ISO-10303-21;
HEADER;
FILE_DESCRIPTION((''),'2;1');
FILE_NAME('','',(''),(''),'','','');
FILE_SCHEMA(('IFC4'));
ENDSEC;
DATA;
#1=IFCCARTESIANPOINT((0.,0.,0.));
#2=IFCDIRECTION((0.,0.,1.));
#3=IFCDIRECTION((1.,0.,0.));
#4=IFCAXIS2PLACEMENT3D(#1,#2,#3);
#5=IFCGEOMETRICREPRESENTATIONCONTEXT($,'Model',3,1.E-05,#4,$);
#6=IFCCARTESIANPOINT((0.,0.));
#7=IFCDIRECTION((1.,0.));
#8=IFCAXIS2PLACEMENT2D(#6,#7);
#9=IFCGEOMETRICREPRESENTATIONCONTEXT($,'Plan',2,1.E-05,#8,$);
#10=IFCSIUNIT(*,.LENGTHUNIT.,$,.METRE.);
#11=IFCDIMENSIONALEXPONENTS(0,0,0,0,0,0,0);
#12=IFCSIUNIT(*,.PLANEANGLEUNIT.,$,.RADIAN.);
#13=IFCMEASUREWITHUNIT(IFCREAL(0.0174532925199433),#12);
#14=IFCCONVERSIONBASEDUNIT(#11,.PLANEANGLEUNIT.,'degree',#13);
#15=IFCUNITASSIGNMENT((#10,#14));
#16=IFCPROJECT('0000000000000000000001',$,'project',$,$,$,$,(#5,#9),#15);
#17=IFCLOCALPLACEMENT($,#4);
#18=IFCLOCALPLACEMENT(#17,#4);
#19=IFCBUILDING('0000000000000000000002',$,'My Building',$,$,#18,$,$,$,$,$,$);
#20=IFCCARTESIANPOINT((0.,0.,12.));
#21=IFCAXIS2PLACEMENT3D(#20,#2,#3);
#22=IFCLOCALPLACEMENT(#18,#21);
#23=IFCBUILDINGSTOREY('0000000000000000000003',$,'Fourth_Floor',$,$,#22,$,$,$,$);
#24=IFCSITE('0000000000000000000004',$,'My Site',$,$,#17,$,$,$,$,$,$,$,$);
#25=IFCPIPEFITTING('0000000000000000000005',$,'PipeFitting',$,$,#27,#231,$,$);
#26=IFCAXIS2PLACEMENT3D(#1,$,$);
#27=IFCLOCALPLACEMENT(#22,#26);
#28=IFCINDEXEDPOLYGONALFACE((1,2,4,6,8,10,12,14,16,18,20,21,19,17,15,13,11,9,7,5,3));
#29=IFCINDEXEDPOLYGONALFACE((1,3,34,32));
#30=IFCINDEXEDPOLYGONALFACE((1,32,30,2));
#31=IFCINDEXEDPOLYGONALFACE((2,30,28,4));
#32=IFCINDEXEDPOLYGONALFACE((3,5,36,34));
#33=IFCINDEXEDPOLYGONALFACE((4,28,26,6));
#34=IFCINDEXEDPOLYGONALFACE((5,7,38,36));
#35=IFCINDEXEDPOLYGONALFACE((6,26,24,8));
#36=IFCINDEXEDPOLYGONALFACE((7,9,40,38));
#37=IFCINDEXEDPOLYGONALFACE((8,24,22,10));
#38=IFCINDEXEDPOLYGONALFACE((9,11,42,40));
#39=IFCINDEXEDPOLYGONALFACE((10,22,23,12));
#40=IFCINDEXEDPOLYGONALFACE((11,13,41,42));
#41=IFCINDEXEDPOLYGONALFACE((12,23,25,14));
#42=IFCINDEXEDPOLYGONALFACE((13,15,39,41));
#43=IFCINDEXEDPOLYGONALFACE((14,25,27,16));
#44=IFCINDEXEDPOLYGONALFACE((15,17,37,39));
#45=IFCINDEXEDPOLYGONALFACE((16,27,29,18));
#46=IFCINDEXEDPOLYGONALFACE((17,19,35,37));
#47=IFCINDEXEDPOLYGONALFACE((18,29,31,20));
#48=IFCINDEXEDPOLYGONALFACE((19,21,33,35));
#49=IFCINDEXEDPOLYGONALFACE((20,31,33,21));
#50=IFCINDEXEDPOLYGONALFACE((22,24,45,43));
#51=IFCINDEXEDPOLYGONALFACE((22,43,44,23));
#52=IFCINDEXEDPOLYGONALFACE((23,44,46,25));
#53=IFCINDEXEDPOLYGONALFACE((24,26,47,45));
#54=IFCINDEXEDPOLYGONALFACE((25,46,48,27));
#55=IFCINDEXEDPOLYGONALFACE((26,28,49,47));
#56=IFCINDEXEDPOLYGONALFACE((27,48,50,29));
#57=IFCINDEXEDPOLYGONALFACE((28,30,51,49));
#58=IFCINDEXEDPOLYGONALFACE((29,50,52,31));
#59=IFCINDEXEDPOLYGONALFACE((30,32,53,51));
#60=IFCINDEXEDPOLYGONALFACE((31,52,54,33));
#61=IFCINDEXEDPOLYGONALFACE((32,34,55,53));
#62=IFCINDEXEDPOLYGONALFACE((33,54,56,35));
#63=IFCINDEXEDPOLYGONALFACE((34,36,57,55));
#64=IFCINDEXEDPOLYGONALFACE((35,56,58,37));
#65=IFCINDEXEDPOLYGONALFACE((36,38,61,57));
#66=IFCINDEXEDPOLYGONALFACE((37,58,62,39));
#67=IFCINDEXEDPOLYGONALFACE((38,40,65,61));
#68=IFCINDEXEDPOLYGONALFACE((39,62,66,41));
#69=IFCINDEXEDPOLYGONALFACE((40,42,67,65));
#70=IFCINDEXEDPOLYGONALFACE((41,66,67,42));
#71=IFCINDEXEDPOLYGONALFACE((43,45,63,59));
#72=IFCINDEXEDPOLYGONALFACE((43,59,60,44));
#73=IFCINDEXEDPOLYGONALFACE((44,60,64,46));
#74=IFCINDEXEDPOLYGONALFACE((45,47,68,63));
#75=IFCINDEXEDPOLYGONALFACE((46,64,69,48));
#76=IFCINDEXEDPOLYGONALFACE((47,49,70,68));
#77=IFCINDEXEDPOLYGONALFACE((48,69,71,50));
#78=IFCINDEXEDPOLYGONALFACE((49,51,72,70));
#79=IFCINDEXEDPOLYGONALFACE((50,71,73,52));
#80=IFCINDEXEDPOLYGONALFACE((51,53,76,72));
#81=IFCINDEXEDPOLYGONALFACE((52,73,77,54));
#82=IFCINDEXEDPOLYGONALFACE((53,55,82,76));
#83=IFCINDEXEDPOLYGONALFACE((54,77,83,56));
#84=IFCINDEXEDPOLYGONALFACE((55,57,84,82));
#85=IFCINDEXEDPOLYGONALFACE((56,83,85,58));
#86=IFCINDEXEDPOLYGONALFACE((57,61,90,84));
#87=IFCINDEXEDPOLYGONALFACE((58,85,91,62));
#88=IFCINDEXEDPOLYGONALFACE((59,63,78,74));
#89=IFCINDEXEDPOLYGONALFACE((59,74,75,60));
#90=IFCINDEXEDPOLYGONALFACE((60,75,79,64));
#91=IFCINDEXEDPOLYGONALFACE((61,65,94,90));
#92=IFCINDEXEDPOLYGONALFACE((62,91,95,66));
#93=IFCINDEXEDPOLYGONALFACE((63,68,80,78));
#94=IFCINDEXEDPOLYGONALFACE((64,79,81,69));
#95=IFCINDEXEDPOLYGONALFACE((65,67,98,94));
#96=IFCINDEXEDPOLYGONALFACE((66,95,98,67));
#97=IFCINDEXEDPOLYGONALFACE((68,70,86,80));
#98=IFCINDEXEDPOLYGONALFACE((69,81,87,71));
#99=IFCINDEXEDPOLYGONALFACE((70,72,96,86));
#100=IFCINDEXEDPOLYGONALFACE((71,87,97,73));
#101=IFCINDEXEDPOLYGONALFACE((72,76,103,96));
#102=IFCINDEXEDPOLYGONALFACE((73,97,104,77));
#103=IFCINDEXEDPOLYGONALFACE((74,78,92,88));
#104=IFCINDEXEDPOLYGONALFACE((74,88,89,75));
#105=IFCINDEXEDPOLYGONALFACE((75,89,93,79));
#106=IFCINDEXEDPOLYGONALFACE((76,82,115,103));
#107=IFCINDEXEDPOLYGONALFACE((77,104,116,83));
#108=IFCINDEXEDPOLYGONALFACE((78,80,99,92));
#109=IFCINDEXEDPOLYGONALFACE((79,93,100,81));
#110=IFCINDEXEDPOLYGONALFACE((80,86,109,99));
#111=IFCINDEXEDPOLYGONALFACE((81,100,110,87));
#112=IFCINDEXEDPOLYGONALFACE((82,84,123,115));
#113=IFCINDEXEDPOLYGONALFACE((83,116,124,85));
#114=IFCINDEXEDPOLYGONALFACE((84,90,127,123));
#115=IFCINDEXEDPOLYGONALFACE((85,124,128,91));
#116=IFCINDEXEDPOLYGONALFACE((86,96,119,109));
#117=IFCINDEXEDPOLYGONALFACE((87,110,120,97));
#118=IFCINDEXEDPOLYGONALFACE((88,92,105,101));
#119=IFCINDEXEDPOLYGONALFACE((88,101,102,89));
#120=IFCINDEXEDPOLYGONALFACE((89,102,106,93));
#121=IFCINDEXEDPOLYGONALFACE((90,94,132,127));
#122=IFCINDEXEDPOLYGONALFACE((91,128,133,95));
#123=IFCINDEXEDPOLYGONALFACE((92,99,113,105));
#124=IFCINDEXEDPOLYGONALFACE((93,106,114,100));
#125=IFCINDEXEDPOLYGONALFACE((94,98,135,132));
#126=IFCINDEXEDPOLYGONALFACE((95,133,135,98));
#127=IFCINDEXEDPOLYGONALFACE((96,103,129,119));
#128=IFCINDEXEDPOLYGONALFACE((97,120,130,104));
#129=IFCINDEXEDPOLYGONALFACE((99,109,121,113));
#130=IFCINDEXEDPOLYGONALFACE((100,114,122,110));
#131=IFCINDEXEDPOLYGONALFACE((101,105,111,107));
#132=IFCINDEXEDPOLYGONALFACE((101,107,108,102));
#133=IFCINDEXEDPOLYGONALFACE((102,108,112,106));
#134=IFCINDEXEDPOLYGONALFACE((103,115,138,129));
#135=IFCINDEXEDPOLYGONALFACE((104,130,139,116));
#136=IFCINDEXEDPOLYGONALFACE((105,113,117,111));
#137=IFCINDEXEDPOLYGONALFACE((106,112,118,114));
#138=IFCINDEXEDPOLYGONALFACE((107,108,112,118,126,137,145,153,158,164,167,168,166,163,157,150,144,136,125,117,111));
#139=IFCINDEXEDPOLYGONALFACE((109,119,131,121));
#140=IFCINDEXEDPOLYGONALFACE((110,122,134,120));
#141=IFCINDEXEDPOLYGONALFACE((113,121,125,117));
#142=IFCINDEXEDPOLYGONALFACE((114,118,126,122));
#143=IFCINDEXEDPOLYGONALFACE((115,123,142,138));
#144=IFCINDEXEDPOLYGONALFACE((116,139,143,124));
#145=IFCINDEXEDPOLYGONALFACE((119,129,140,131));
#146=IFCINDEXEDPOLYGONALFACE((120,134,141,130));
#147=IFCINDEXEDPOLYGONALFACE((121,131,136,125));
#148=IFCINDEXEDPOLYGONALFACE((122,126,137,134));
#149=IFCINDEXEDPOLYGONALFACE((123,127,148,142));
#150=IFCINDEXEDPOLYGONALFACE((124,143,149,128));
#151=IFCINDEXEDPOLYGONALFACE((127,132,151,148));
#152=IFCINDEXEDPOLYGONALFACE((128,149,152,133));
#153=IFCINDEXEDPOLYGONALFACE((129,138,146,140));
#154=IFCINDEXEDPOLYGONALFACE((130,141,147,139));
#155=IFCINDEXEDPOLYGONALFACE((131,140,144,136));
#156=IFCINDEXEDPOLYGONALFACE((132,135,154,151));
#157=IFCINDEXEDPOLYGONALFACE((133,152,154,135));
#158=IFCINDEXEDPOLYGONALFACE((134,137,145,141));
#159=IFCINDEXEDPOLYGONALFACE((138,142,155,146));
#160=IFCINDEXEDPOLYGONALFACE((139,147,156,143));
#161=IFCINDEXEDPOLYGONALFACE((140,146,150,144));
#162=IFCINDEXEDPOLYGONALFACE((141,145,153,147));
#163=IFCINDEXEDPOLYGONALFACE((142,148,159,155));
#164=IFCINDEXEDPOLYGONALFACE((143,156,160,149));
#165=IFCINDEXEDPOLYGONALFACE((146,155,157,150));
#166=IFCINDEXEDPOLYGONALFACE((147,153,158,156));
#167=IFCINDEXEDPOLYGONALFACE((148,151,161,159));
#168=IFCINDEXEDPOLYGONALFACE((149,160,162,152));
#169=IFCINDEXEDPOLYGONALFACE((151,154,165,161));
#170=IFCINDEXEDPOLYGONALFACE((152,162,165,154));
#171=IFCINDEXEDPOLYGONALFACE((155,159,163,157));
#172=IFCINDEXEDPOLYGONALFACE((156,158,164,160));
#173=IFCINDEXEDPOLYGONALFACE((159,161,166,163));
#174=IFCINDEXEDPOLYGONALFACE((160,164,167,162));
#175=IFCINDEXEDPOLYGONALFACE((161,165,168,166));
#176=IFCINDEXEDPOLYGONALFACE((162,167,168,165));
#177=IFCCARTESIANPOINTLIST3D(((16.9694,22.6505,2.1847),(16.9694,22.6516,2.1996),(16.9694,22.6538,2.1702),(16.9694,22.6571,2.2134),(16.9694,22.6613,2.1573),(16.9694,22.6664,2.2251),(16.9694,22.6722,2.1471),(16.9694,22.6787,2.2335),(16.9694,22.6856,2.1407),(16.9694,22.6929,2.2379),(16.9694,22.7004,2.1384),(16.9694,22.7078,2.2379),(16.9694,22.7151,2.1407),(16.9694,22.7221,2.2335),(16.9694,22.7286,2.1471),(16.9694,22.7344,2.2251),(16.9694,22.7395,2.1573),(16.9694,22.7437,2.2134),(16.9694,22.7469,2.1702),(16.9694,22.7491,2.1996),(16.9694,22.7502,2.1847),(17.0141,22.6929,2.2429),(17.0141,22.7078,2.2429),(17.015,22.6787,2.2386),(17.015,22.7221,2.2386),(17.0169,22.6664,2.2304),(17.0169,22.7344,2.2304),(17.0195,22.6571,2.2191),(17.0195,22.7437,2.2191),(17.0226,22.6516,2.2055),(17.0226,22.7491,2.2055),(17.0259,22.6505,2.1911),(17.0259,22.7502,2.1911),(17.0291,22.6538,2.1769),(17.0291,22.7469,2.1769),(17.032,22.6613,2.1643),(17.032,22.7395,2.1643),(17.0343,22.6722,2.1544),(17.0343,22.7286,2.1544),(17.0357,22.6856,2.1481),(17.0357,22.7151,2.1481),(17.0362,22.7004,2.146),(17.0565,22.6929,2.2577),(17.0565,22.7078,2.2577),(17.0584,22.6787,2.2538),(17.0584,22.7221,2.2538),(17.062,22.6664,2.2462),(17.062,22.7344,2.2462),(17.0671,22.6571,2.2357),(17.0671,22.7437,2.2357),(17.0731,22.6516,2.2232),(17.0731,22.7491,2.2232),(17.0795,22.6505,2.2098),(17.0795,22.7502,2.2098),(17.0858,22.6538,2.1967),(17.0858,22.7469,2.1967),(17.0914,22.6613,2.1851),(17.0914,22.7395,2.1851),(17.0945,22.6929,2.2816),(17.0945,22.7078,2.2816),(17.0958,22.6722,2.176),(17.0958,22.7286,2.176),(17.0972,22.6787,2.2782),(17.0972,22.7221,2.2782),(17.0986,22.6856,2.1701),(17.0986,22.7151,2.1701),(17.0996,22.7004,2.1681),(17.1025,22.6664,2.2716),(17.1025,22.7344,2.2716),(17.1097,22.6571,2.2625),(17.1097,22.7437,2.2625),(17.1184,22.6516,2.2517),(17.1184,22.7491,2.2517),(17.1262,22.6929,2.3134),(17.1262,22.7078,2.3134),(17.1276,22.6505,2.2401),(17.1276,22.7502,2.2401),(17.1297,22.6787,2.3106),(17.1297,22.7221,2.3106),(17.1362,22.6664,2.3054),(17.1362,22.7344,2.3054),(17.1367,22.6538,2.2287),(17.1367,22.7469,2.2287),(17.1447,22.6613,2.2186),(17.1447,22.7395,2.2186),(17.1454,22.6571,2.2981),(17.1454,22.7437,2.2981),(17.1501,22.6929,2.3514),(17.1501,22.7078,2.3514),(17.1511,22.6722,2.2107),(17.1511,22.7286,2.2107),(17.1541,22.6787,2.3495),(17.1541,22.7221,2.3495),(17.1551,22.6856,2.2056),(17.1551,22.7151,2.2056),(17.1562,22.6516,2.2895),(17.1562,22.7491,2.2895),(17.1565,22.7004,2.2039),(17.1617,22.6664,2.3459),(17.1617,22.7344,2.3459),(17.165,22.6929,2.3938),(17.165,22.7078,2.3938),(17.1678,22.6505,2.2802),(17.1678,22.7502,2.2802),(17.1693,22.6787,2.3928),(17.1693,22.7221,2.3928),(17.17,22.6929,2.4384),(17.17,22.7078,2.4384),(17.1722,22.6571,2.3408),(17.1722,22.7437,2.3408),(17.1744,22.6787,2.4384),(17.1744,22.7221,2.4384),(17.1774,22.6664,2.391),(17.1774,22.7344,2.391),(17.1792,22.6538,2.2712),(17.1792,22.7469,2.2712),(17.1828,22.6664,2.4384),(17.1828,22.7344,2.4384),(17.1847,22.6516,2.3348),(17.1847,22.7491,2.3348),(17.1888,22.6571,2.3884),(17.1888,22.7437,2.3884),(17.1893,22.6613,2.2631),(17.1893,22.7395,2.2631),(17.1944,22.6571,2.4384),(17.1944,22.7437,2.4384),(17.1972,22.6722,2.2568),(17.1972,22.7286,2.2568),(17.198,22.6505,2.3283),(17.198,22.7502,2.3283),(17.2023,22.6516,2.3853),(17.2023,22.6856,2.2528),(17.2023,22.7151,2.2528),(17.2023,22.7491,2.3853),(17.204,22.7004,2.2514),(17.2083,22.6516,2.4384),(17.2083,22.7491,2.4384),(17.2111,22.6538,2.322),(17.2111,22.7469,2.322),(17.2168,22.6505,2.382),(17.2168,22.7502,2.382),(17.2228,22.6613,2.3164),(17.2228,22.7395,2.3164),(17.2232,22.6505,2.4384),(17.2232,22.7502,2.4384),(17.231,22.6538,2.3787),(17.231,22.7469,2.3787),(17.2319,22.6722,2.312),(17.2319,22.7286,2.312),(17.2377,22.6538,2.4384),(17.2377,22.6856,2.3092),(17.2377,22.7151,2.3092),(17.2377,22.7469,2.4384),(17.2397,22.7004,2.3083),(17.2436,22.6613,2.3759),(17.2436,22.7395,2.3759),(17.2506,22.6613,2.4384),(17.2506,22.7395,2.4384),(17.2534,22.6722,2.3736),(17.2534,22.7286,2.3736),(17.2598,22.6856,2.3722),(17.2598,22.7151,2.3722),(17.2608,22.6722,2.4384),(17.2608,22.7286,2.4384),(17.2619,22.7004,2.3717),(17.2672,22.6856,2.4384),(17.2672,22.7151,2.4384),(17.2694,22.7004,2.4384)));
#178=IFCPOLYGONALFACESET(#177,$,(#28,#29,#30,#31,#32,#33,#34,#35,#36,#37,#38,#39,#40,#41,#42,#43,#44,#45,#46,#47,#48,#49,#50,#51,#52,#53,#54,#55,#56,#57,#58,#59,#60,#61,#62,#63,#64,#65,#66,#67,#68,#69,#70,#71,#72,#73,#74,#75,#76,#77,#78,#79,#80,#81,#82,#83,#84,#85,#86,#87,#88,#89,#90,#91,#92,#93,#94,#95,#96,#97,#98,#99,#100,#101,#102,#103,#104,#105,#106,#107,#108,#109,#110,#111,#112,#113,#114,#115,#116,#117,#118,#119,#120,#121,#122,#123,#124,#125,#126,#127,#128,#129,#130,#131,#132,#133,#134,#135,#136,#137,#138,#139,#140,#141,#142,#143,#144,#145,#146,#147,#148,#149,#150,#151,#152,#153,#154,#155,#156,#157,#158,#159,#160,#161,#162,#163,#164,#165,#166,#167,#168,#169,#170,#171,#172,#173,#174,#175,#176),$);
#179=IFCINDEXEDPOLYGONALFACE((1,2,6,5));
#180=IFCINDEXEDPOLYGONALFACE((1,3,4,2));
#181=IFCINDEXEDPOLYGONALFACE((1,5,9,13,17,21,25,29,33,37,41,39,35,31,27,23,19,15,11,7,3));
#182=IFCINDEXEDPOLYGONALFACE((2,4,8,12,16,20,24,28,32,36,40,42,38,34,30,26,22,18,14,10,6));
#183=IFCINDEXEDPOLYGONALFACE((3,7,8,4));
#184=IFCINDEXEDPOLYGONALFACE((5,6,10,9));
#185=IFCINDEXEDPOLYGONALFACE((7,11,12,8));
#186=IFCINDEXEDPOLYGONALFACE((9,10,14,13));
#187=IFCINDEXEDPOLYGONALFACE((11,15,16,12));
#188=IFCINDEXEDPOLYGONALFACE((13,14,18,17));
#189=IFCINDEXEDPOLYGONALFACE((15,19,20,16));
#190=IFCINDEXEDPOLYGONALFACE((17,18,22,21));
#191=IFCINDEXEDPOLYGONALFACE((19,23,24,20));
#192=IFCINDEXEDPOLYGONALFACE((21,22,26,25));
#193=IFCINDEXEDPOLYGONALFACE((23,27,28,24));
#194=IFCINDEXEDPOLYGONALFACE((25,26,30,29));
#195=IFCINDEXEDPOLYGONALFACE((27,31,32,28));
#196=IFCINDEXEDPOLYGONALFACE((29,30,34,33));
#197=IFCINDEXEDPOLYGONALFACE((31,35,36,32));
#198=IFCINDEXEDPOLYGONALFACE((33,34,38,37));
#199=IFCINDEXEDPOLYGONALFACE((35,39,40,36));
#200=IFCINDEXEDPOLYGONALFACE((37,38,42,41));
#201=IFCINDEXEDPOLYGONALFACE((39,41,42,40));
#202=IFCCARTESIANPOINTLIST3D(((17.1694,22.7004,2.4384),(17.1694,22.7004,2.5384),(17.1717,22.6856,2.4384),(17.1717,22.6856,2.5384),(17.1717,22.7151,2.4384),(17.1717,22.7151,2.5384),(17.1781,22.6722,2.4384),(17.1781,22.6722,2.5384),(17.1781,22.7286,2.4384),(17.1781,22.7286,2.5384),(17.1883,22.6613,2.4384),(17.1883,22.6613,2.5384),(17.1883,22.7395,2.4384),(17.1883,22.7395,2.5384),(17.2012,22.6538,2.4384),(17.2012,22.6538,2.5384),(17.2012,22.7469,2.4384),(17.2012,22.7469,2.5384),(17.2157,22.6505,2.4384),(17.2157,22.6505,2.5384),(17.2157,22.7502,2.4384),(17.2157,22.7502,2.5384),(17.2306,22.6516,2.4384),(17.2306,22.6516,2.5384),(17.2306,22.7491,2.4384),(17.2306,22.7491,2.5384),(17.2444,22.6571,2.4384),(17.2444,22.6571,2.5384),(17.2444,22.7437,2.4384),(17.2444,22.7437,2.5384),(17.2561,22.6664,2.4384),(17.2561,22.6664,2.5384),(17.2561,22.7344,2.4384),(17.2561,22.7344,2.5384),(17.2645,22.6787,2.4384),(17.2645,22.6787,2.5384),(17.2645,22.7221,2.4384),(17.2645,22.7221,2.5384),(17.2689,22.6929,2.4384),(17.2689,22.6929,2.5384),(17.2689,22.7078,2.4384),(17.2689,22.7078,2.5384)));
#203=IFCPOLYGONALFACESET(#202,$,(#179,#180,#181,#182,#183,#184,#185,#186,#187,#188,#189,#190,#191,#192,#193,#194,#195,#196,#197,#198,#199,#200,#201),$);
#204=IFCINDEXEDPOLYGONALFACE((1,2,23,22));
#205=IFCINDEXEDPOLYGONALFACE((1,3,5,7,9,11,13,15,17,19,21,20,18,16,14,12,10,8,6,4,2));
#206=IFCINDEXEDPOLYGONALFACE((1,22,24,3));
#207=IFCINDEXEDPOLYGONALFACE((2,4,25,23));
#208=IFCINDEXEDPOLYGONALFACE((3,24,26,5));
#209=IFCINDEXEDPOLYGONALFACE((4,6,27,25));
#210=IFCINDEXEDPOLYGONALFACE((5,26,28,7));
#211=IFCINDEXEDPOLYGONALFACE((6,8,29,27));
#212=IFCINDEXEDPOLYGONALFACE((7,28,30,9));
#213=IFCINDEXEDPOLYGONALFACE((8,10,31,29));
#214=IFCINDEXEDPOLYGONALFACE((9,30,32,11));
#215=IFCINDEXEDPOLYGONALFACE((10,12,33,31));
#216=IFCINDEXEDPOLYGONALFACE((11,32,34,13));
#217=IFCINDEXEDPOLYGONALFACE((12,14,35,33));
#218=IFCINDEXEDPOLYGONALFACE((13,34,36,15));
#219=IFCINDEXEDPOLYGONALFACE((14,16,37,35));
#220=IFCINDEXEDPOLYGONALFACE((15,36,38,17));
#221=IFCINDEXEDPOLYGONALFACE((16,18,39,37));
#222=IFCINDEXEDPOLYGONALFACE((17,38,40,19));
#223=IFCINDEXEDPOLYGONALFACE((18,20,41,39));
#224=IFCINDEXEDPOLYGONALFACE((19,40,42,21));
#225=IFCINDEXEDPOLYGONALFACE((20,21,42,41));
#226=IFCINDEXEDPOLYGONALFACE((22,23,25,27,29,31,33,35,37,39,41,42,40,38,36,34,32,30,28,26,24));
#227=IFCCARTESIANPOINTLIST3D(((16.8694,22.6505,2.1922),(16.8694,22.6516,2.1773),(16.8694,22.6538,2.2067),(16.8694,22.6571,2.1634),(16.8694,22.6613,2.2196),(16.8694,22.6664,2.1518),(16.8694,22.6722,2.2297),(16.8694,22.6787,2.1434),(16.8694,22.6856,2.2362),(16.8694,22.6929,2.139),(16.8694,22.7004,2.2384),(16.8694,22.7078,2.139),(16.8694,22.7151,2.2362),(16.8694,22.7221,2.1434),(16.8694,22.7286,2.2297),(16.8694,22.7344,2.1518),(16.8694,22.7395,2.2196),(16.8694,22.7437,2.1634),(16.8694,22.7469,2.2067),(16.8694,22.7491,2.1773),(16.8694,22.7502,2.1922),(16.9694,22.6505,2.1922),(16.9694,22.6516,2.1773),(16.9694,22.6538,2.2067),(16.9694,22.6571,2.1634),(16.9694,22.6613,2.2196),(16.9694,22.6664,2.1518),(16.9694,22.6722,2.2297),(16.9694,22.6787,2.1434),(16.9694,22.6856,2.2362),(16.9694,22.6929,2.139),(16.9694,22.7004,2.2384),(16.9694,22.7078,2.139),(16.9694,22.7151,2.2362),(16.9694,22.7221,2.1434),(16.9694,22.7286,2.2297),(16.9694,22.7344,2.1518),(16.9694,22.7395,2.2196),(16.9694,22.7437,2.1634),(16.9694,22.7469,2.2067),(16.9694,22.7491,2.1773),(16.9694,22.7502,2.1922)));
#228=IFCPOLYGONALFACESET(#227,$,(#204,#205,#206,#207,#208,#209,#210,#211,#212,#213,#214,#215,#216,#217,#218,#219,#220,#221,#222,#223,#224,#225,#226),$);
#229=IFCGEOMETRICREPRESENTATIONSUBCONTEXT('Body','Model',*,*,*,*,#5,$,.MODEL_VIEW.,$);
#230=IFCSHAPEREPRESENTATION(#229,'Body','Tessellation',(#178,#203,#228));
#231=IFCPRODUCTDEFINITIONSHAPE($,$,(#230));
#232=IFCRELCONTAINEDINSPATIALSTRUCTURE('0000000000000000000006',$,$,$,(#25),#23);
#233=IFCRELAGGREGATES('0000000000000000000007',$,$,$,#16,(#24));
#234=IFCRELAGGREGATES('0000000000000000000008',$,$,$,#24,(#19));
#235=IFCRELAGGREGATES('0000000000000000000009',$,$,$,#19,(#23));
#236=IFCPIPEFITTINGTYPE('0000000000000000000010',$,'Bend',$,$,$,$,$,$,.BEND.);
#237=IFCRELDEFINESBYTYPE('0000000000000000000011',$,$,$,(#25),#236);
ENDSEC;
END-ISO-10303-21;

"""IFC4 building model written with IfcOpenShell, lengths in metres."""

from ifc_helpers import new_model, entity, si_unit, converted_unit, frame, origin_with_axes, origin_2d_with_axis, place, context, subcontext, project, spatial, circle, extrude, source, transform, mapped, type_object, type_shapes, element, save


model = new_model("IFC4")

# Units and contexts
model_context = context("Model", 3, precision=1e-05, world=origin_with_axes())
plan_context = context("Plan", 2, precision=1e-05, world=origin_2d_with_axis())
body_context = subcontext(model_context, "Body", "Model", "MODEL_VIEW")
ifc_project = project(units=[si_unit("LENGTHUNIT", "METRE"), converted_unit("PLANEANGLEUNIT", "degree", entity("IfcReal", 0.0174532925199433), si_unit("PLANEANGLEUNIT", "RADIAN"), dimensions=[0, 0, 0, 0, 0, 0, 0])], contexts=[model_context, plan_context])

# Site, building, storey
site_placement = place(None, origin_with_axes())
site = spatial("IfcSite", under=ifc_project, at=site_placement, Name="My Site")
building_placement = place(site_placement, origin_with_axes())
building = spatial("IfcBuilding", under=site, at=building_placement, Name="My Building")
storey_placement = place(building_placement, frame((0.0, 0.0, 12.0), z_axis=(0.0, 0.0, 1.0), x_axis=(1.0, 0.0, 0.0)))
storey = spatial("IfcBuildingStorey", under=building, at=storey_placement, Name="Fourth_Floor")

# Pipe fitting
pipe_fitting_type = type_object("IfcPipeFittingType", Name="Bend", PredefinedType="BEND")
shared_shape = source(origin_with_axes(), body_context, "Body", "SolidModel", [
    entity("IfcSweptDiskSolid", entity("IfcIndexedPolyCurve", entity("IfcCartesianPointList3D", [[0.0, 0.0, -0.1], [0.0732, 0.0, -0.2768], [0.25, 0.0, -0.35]]), [entity("IfcArcIndex", [1, 2, 3])]), 0.05),
    extrude(circle(Radius=0.05), origin_with_axes(), (0.0, 0.0, -1.0), 0.1),
    extrude(circle(Radius=0.05), frame((0.25, 0.0, -0.35), z_axis=(1.0, 0.0, 0.0), x_axis=(0.0, 0.0, 1.0)), (0.0, 0.0, 1.0), 0.1),
])
type_shapes(pipe_fitting_type, [shared_shape])
for number, where, z_axis, x_axis, name in (
    (1, (17.2194, 22.7004, 2.5384), (0.0, 0.0, 1.0), (-1.0, 0.0, 0.0), "PipeFitting"),
):
    element("IfcPipeFitting", number, at=place(storey_placement, frame(where, z_axis=z_axis, x_axis=x_axis)), inside=storey, type_object=pipe_fitting_type, Name=name, context=body_context, shape_type="MappedRepresentation", body=[
        mapped(shared_shape, transform((0.0, 0.0, 0.0), x_axis=(1.0, 0.0, 0.0), y_axis=(0.0, 1.0, 0.0), z_axis=(0.0, 0.0, 1.0), scale=1.0)),
    ])

save(model, "model.ifc")
